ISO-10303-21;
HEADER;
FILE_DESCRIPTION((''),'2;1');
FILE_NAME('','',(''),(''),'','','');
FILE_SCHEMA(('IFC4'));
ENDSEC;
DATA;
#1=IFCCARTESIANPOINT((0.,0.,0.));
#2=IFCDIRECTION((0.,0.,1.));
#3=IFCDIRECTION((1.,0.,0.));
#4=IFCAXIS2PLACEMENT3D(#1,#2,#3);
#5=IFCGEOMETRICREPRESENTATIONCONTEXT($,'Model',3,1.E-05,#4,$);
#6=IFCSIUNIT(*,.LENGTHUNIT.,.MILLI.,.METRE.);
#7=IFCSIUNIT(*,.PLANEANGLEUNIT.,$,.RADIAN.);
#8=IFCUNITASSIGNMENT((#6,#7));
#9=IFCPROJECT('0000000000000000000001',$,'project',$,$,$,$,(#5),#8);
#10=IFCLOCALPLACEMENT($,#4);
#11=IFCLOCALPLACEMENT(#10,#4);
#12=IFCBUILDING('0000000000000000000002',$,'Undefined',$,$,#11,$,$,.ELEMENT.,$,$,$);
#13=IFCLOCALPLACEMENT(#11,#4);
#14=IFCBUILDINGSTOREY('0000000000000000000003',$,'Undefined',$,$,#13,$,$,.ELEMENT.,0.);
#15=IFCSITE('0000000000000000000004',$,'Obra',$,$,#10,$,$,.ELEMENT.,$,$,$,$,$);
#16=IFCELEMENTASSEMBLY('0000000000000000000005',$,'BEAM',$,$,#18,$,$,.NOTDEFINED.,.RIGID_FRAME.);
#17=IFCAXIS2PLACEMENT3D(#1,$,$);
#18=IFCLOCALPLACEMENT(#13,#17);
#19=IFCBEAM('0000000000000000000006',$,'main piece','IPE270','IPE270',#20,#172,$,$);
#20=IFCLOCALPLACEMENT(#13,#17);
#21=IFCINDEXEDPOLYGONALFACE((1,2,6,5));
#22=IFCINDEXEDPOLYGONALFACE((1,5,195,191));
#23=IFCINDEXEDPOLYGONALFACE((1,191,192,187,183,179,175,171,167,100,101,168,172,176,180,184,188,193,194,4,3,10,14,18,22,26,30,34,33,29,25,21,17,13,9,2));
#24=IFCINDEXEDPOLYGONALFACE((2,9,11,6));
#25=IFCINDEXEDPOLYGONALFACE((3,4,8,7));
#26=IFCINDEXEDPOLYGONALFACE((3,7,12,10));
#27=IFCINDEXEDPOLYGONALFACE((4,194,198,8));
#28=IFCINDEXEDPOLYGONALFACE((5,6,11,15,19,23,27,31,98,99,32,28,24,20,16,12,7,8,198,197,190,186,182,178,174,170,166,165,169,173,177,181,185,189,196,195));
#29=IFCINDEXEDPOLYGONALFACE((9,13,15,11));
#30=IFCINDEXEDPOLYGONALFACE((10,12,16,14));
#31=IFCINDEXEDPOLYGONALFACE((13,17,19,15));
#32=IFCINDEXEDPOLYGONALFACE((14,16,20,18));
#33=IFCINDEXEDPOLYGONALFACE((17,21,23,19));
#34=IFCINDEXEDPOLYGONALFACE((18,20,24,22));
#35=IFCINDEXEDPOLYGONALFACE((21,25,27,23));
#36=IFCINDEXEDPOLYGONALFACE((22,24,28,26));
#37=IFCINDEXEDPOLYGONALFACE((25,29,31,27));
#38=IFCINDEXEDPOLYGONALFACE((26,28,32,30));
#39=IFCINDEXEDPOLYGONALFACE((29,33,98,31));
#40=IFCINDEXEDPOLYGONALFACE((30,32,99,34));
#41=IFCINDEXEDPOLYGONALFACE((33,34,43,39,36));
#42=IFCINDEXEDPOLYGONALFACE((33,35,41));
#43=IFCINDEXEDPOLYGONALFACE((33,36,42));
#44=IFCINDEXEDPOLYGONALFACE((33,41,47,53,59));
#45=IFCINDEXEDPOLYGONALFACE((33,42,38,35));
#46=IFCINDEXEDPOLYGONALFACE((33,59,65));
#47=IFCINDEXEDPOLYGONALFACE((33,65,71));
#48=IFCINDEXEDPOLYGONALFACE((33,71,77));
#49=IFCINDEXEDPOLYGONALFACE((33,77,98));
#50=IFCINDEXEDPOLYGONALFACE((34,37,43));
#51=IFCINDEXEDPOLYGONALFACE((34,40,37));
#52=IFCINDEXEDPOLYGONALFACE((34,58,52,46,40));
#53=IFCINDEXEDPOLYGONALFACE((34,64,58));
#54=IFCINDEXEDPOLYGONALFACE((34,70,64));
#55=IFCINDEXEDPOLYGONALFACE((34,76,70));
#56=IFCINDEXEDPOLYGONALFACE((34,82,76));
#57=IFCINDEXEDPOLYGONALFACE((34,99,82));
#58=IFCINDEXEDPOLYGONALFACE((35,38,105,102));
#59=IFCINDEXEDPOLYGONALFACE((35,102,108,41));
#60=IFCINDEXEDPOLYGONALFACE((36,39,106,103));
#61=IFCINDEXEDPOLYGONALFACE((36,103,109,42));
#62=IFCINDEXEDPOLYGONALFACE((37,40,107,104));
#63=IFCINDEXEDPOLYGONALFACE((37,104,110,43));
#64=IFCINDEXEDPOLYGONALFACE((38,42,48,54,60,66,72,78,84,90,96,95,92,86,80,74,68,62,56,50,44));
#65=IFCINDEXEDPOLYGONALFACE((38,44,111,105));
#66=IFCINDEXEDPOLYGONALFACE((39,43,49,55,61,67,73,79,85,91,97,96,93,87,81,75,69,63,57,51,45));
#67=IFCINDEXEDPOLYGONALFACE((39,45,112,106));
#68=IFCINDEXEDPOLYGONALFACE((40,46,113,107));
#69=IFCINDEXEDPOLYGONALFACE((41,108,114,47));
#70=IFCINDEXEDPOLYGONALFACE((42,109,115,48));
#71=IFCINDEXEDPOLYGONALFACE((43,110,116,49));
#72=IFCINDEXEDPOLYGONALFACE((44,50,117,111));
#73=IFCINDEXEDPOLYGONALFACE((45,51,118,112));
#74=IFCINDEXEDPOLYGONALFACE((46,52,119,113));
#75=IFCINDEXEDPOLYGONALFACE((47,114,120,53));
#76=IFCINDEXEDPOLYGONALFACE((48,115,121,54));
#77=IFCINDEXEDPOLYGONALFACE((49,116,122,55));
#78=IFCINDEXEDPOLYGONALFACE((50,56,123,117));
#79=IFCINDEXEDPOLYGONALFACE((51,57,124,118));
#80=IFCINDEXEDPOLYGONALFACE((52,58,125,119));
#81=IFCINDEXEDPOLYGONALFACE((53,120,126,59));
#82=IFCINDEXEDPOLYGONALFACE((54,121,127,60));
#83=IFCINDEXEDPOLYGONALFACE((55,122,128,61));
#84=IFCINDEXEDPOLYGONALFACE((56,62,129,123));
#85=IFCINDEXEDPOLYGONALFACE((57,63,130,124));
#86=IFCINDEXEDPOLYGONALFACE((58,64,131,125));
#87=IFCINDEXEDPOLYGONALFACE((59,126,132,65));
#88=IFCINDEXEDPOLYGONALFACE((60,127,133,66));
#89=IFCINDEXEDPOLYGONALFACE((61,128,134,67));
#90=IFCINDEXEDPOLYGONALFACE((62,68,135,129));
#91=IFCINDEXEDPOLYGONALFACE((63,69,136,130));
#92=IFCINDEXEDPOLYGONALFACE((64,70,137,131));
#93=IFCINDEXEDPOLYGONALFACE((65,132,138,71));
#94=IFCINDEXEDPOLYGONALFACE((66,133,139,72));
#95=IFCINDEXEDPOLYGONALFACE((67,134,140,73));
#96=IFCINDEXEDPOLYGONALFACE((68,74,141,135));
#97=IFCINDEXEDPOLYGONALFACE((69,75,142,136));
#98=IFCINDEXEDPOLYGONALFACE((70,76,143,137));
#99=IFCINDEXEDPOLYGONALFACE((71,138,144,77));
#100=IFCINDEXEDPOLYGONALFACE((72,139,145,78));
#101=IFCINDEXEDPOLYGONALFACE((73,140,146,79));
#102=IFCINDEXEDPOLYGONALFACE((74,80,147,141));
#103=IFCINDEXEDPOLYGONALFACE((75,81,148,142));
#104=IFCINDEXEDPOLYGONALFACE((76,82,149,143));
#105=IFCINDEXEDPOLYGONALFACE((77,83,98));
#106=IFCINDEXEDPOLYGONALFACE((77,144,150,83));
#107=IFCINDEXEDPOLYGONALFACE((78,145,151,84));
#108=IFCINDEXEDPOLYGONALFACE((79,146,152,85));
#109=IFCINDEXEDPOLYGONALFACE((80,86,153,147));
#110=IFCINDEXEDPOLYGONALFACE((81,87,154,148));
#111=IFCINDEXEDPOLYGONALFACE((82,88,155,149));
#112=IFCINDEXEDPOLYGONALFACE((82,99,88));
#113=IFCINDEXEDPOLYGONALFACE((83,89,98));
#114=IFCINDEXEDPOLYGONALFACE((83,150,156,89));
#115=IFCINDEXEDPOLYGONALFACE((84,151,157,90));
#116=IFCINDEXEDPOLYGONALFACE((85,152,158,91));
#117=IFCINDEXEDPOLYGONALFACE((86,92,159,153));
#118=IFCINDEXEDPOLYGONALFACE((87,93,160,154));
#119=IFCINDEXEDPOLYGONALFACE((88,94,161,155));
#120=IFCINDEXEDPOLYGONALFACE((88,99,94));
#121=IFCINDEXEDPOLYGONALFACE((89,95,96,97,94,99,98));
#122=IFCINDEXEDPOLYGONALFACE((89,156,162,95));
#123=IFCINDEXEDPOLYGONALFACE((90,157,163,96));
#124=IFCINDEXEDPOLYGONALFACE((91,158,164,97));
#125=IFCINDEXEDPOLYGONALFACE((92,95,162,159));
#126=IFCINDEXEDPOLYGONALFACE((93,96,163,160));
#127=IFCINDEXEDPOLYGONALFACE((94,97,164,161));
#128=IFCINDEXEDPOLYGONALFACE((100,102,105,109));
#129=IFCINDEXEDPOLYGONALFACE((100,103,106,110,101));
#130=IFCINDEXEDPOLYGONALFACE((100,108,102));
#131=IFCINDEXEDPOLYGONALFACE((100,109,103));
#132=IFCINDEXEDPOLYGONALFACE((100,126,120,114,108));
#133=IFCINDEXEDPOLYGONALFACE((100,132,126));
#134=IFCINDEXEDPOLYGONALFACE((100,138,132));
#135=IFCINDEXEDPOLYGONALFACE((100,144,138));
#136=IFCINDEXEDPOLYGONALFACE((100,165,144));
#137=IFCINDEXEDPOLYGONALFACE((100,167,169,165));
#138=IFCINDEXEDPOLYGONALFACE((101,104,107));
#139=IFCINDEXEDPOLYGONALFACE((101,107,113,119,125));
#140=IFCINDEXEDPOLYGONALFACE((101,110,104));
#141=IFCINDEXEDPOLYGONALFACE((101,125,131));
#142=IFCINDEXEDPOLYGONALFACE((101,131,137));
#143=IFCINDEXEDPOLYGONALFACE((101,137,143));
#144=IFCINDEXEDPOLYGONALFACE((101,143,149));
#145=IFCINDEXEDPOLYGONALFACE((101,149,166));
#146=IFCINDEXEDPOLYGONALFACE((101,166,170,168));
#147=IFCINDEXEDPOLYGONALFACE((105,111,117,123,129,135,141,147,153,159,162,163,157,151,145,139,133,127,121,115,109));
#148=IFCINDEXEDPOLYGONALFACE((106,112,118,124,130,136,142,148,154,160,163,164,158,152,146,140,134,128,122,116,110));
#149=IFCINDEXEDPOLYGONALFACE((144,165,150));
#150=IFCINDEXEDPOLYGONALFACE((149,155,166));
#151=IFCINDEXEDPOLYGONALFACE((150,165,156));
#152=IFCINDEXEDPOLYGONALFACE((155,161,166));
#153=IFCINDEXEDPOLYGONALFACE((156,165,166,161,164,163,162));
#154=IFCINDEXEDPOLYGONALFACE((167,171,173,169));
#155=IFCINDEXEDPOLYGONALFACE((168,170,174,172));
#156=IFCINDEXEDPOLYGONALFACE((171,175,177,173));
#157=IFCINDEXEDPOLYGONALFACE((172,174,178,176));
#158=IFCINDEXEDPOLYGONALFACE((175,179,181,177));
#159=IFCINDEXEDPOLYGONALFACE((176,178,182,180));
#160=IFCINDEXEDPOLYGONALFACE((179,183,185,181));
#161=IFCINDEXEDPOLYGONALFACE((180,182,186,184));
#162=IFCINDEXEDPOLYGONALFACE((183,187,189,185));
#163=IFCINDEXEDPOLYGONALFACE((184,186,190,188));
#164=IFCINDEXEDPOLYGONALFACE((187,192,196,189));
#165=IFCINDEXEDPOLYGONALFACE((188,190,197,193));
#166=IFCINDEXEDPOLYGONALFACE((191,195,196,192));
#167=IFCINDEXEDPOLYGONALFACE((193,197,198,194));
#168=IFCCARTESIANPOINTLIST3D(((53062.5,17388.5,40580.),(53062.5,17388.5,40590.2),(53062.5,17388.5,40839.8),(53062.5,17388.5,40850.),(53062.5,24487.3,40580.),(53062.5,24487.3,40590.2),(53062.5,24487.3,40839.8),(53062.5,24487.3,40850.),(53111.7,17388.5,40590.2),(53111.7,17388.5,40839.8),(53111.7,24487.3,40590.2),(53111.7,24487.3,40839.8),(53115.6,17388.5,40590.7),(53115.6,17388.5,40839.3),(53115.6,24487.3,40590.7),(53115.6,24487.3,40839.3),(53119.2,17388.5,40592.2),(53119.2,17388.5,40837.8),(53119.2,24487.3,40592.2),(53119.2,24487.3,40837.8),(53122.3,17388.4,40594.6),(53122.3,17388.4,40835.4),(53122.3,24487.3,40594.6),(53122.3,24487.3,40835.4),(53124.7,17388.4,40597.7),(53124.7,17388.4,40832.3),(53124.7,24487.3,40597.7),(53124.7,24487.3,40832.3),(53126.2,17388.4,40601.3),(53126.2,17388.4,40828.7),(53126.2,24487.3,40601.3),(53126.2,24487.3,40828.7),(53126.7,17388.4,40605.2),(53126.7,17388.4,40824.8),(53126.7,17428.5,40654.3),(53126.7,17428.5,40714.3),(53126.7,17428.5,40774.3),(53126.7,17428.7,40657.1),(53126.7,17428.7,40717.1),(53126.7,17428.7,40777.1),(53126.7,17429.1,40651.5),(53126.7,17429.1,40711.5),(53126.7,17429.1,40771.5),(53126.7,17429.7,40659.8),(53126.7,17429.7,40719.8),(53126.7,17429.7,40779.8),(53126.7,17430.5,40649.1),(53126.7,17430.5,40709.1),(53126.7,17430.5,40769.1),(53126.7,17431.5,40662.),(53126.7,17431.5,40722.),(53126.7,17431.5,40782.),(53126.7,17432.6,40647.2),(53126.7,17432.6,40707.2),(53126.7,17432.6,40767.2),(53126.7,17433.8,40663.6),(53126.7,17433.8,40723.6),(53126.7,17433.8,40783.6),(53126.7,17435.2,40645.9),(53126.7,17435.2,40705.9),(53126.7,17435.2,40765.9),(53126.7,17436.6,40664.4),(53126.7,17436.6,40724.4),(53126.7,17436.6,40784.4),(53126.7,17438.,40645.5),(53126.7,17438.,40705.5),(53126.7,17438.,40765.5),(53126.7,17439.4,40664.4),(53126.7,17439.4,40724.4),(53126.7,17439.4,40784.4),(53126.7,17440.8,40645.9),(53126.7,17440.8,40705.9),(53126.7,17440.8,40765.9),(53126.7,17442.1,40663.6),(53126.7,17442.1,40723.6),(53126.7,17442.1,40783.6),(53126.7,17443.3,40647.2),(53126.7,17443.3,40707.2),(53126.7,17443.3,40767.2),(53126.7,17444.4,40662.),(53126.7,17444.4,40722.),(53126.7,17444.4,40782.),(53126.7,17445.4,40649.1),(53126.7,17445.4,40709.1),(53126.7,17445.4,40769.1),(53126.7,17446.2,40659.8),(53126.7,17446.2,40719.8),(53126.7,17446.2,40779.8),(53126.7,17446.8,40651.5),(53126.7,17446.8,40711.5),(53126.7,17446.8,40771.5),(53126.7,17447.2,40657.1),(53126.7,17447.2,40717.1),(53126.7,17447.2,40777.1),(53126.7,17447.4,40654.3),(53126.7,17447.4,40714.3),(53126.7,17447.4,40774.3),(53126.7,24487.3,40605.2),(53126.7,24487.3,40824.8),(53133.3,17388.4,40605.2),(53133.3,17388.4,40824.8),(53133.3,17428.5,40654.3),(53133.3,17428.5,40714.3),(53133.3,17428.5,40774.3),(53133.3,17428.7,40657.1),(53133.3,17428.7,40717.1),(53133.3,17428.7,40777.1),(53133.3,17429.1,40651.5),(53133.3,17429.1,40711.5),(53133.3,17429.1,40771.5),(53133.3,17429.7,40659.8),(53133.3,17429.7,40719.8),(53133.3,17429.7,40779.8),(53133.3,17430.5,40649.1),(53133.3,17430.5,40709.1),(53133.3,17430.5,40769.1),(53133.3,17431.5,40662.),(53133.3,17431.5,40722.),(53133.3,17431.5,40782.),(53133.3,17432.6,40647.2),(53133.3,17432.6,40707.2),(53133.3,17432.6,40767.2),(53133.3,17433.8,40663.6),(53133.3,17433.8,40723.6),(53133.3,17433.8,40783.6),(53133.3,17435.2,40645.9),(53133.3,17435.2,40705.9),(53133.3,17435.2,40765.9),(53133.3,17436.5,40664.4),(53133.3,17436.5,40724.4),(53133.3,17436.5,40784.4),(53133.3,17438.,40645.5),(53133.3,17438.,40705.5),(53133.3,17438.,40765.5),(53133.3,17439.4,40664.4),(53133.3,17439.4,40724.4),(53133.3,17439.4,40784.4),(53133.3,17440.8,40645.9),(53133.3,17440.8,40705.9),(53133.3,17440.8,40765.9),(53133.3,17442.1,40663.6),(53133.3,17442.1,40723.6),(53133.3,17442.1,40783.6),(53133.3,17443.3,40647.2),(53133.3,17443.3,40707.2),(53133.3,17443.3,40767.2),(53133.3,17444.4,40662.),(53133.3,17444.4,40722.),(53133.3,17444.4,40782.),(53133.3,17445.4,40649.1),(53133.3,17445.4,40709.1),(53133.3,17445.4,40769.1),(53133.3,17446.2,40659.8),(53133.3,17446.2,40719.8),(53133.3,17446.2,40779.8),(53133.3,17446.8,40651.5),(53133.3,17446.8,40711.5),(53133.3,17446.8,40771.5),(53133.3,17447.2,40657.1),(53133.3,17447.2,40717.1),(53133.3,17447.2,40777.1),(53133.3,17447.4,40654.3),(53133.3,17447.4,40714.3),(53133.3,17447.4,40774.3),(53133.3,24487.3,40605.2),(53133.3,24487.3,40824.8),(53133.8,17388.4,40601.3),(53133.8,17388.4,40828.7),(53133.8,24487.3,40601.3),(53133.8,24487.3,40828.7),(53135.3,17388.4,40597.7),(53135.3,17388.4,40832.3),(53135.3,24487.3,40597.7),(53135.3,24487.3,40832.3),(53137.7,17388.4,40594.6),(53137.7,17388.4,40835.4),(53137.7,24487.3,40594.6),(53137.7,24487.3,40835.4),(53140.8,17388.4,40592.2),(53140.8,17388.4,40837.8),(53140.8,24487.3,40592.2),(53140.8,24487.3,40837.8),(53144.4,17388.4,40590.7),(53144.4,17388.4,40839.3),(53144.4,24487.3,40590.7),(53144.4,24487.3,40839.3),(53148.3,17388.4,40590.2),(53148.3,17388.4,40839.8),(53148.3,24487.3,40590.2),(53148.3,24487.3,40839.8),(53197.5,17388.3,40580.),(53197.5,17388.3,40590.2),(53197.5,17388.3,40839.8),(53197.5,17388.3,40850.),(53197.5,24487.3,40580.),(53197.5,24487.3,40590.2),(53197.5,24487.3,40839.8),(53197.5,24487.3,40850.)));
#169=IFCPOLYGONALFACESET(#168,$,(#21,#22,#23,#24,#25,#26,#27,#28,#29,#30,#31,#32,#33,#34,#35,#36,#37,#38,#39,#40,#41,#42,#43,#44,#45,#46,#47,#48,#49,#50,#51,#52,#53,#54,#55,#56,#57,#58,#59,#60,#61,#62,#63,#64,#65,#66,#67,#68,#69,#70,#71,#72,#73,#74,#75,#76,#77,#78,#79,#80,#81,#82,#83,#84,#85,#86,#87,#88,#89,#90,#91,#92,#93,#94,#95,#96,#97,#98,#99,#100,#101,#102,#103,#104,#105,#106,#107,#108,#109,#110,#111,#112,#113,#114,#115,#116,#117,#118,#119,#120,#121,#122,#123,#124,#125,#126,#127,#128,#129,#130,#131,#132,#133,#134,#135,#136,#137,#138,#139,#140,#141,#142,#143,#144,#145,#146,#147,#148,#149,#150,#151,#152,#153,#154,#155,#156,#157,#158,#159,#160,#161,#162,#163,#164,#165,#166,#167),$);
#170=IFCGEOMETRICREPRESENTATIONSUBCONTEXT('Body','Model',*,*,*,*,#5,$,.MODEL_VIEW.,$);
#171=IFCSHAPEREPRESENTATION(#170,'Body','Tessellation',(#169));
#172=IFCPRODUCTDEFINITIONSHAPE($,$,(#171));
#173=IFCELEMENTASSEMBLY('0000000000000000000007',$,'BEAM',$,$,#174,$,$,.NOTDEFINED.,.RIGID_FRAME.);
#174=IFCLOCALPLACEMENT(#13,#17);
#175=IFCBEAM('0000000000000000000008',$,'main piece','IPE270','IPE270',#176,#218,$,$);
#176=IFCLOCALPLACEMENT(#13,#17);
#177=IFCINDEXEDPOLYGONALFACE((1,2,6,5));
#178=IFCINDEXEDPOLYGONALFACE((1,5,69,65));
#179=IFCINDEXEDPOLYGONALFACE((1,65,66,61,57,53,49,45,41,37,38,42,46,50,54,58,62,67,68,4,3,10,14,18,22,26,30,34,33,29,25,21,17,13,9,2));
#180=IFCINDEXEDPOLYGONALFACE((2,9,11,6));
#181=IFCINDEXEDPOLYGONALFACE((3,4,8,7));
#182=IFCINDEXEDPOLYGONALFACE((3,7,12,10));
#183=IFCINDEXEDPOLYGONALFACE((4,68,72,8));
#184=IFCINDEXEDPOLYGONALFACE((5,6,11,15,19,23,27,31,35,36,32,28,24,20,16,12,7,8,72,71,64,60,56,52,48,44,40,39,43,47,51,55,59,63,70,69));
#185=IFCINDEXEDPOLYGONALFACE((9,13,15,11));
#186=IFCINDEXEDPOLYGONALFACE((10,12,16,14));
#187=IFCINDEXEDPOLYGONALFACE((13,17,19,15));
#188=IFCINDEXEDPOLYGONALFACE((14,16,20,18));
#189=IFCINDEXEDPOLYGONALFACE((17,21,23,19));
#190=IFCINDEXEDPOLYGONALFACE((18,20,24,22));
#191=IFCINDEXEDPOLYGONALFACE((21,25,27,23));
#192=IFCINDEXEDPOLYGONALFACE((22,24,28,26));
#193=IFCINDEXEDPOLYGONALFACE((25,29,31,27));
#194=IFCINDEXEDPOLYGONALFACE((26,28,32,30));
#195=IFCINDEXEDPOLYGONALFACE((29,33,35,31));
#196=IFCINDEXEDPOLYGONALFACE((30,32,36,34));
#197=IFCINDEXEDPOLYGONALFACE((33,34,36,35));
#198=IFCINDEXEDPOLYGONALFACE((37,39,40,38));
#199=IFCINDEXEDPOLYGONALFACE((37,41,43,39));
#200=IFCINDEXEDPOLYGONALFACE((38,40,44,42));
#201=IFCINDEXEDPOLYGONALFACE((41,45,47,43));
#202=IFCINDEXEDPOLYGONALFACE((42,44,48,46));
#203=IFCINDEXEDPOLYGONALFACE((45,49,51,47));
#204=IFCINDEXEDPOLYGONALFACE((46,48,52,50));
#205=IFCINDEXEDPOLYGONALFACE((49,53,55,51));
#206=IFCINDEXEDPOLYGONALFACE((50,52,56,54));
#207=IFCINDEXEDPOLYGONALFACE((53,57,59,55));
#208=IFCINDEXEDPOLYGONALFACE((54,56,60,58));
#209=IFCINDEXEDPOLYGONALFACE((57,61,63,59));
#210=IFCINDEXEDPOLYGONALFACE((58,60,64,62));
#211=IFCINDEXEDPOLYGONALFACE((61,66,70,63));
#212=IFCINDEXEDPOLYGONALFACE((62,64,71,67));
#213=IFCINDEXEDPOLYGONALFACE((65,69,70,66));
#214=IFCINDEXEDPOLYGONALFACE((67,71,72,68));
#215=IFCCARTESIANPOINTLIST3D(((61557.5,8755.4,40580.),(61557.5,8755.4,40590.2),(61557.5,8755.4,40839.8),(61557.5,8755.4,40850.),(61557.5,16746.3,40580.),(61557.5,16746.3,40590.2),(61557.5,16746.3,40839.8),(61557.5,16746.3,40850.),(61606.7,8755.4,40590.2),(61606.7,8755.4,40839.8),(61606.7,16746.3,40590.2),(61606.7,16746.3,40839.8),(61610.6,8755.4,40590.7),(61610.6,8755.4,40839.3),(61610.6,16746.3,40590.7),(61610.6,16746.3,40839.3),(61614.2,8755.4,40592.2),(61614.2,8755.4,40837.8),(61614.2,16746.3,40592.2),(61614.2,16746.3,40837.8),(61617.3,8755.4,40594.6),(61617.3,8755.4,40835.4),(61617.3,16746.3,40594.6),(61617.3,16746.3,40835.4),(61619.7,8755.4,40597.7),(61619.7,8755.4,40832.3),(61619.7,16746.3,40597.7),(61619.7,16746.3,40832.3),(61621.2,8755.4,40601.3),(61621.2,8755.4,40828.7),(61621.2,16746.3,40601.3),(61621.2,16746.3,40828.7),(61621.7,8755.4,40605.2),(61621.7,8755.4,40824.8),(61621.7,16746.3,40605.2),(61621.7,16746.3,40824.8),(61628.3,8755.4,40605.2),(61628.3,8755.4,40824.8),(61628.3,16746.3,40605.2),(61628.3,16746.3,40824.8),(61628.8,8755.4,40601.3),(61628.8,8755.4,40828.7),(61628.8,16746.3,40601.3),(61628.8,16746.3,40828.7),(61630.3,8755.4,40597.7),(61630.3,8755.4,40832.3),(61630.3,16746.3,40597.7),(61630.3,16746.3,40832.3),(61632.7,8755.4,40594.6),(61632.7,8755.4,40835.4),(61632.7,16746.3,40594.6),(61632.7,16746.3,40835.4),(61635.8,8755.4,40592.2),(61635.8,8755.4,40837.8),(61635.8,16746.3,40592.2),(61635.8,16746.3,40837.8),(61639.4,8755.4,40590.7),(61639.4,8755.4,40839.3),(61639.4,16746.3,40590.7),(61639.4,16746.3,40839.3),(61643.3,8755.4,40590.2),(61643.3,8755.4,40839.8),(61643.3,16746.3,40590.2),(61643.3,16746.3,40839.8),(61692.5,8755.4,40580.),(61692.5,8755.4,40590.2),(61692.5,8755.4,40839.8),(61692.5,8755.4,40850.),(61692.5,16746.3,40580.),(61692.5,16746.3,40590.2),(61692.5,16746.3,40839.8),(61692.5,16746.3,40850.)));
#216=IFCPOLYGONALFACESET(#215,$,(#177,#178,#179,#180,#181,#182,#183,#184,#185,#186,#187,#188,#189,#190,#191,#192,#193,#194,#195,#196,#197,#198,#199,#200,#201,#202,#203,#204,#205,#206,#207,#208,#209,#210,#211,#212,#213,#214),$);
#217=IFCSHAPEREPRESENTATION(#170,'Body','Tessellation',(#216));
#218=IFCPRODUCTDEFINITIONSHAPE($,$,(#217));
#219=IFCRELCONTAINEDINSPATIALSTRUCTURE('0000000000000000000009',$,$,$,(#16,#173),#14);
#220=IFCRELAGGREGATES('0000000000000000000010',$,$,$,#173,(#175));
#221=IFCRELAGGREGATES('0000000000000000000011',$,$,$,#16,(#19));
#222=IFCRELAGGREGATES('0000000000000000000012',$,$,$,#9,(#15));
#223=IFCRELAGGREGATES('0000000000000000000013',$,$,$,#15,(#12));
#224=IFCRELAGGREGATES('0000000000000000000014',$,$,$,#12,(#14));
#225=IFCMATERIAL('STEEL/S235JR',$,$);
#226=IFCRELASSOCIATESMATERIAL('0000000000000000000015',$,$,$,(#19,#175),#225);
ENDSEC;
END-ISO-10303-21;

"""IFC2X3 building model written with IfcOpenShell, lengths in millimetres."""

from ifc_helpers import new_model, si_unit, frame, origin_with_axes, origin_2d_with_axis, place, context, subcontext, project, spatial, circle, i_section, extrude, clip, halfspace, source, transform, mapped, material, element, aggregate, save


model = new_model("IFC2X3")

# Units and contexts
model_context = context("Model", 3, precision=1e-05, world=origin_with_axes())
body_context = subcontext(model_context, "Body", "Model", "MODEL_VIEW")
ifc_project = project(units=[si_unit("LENGTHUNIT", "METRE", prefix="MILLI"), si_unit("PLANEANGLEUNIT", "RADIAN")], contexts=[model_context])

# Site, building, storey
site_placement = place(None, origin_with_axes())
site = spatial("IfcSite", under=ifc_project, at=site_placement, Name="Obra", CompositionType="ELEMENT")
building_placement = place(site_placement, origin_with_axes())
building = spatial("IfcBuilding", under=site, at=building_placement, Name="Undefined", CompositionType="ELEMENT")
storey_placement = place(building_placement, origin_with_axes())
storey = spatial("IfcBuildingStorey", under=building, at=storey_placement, Name="Undefined", CompositionType="ELEMENT", Elevation=0.0)

# Shared definitions
ifc_material_1 = material(Name="STEEL/S235JR")

# Element assembly, beam, opening
assembly_1_placement = place(storey_placement, origin_with_axes())
assembly_1 = element("IfcElementAssembly", 1, at=assembly_1_placement, inside=storey, Name="BEAM", AssemblyPlace="NOTDEFINED", PredefinedType="RIGID_FRAME")
beam_1_placement = place(assembly_1_placement, frame((53130.0, 17375.3, 40715.0), z_axis=(0.0, 0.0, 1.0), x_axis=(0.0, 1.0, 0.0)))
beam_1 = element("IfcBeam", 2, at=beam_1_placement, material=ifc_material_1, Name="main piece", Description="IPE270", ObjectType="IPE270", context=body_context, shape_type="Clipping", body=[
    clip(extrude(i_section(OverallWidth=135.0, OverallDepth=270.0, WebThickness=6.6, FlangeThickness=10.2, FilletRadius=15.0, at=origin_2d_with_axis()), frame((7112.0, 0.0, 0.0), z_axis=(-1.0, 0.0, 0.0), x_axis=(0.0, -1.0, 0.0)), (0.0, 0.0, 1.0), 7112.0), halfspace(frame((13.3, 59.2, -120.0), z_axis=(-0.999999, 0.00163, 0.0), x_axis=(0.0, 0.0, 1.0)), False)),
])
shared_shape_1 = source(origin_with_axes(), body_context, "Body", "SweptSolid", [
    extrude(circle(Radius=9.5, at=origin_2d_with_axis()), frame((0.0, -2.5, 0.0), z_axis=(0.0, 1.0, 0.0), x_axis=(1.0, 0.0, 0.0)), (0.0, 0.0, 1.0), 6.8),
])
opening_1_placement = place(assembly_1_placement, frame((53130.8, 17388.0, 40835.0), z_axis=(0.001649, 0.999999, 0.0), x_axis=(0.0, 0.0, -1.0)))
element("IfcOpeningElement", 3, at=opening_1_placement, cuts=beam_1, ObjectType="Opening", context=body_context, shape_type="MappedRepresentation", body=[
    mapped(shared_shape_1, transform((60.0, 0.0, 50.0))),
    mapped(shared_shape_1, transform((120.0, 0.0, 50.0))),
    mapped(shared_shape_1, transform((180.0, 0.0, 50.0))),
])

# Element assembly, beam
assembly_2_placement = place(storey_placement, origin_with_axes())
assembly_2 = element("IfcElementAssembly", 4, at=assembly_2_placement, inside=storey, Name="BEAM", AssemblyPlace="NOTDEFINED", PredefinedType="RIGID_FRAME")
beam_2_placement = place(assembly_2_placement, frame((61625.0, 16746.3, 40715.0), z_axis=(0.0, 0.0, 1.0), x_axis=(0.0, -1.0, 0.0)))
beam_2 = element("IfcBeam", 5, at=beam_2_placement, material=ifc_material_1, Name="main piece", Description="IPE270", ObjectType="IPE270", context=body_context, shape_type="SweptSolid", body=[
    extrude(i_section(OverallWidth=135.0, OverallDepth=270.0, WebThickness=6.6, FlangeThickness=10.2, FilletRadius=15.0, at=origin_2d_with_axis()), frame((7990.9, 0.0, 0.0), z_axis=(-1.0, 0.0, 0.0), x_axis=(0.0, -1.0, 0.0)), (0.0, 0.0, 1.0), 7990.9),
])
aggregate(assembly_2, [beam_2])

aggregate(assembly_1, [beam_1])

save(model, "model.ifc")
